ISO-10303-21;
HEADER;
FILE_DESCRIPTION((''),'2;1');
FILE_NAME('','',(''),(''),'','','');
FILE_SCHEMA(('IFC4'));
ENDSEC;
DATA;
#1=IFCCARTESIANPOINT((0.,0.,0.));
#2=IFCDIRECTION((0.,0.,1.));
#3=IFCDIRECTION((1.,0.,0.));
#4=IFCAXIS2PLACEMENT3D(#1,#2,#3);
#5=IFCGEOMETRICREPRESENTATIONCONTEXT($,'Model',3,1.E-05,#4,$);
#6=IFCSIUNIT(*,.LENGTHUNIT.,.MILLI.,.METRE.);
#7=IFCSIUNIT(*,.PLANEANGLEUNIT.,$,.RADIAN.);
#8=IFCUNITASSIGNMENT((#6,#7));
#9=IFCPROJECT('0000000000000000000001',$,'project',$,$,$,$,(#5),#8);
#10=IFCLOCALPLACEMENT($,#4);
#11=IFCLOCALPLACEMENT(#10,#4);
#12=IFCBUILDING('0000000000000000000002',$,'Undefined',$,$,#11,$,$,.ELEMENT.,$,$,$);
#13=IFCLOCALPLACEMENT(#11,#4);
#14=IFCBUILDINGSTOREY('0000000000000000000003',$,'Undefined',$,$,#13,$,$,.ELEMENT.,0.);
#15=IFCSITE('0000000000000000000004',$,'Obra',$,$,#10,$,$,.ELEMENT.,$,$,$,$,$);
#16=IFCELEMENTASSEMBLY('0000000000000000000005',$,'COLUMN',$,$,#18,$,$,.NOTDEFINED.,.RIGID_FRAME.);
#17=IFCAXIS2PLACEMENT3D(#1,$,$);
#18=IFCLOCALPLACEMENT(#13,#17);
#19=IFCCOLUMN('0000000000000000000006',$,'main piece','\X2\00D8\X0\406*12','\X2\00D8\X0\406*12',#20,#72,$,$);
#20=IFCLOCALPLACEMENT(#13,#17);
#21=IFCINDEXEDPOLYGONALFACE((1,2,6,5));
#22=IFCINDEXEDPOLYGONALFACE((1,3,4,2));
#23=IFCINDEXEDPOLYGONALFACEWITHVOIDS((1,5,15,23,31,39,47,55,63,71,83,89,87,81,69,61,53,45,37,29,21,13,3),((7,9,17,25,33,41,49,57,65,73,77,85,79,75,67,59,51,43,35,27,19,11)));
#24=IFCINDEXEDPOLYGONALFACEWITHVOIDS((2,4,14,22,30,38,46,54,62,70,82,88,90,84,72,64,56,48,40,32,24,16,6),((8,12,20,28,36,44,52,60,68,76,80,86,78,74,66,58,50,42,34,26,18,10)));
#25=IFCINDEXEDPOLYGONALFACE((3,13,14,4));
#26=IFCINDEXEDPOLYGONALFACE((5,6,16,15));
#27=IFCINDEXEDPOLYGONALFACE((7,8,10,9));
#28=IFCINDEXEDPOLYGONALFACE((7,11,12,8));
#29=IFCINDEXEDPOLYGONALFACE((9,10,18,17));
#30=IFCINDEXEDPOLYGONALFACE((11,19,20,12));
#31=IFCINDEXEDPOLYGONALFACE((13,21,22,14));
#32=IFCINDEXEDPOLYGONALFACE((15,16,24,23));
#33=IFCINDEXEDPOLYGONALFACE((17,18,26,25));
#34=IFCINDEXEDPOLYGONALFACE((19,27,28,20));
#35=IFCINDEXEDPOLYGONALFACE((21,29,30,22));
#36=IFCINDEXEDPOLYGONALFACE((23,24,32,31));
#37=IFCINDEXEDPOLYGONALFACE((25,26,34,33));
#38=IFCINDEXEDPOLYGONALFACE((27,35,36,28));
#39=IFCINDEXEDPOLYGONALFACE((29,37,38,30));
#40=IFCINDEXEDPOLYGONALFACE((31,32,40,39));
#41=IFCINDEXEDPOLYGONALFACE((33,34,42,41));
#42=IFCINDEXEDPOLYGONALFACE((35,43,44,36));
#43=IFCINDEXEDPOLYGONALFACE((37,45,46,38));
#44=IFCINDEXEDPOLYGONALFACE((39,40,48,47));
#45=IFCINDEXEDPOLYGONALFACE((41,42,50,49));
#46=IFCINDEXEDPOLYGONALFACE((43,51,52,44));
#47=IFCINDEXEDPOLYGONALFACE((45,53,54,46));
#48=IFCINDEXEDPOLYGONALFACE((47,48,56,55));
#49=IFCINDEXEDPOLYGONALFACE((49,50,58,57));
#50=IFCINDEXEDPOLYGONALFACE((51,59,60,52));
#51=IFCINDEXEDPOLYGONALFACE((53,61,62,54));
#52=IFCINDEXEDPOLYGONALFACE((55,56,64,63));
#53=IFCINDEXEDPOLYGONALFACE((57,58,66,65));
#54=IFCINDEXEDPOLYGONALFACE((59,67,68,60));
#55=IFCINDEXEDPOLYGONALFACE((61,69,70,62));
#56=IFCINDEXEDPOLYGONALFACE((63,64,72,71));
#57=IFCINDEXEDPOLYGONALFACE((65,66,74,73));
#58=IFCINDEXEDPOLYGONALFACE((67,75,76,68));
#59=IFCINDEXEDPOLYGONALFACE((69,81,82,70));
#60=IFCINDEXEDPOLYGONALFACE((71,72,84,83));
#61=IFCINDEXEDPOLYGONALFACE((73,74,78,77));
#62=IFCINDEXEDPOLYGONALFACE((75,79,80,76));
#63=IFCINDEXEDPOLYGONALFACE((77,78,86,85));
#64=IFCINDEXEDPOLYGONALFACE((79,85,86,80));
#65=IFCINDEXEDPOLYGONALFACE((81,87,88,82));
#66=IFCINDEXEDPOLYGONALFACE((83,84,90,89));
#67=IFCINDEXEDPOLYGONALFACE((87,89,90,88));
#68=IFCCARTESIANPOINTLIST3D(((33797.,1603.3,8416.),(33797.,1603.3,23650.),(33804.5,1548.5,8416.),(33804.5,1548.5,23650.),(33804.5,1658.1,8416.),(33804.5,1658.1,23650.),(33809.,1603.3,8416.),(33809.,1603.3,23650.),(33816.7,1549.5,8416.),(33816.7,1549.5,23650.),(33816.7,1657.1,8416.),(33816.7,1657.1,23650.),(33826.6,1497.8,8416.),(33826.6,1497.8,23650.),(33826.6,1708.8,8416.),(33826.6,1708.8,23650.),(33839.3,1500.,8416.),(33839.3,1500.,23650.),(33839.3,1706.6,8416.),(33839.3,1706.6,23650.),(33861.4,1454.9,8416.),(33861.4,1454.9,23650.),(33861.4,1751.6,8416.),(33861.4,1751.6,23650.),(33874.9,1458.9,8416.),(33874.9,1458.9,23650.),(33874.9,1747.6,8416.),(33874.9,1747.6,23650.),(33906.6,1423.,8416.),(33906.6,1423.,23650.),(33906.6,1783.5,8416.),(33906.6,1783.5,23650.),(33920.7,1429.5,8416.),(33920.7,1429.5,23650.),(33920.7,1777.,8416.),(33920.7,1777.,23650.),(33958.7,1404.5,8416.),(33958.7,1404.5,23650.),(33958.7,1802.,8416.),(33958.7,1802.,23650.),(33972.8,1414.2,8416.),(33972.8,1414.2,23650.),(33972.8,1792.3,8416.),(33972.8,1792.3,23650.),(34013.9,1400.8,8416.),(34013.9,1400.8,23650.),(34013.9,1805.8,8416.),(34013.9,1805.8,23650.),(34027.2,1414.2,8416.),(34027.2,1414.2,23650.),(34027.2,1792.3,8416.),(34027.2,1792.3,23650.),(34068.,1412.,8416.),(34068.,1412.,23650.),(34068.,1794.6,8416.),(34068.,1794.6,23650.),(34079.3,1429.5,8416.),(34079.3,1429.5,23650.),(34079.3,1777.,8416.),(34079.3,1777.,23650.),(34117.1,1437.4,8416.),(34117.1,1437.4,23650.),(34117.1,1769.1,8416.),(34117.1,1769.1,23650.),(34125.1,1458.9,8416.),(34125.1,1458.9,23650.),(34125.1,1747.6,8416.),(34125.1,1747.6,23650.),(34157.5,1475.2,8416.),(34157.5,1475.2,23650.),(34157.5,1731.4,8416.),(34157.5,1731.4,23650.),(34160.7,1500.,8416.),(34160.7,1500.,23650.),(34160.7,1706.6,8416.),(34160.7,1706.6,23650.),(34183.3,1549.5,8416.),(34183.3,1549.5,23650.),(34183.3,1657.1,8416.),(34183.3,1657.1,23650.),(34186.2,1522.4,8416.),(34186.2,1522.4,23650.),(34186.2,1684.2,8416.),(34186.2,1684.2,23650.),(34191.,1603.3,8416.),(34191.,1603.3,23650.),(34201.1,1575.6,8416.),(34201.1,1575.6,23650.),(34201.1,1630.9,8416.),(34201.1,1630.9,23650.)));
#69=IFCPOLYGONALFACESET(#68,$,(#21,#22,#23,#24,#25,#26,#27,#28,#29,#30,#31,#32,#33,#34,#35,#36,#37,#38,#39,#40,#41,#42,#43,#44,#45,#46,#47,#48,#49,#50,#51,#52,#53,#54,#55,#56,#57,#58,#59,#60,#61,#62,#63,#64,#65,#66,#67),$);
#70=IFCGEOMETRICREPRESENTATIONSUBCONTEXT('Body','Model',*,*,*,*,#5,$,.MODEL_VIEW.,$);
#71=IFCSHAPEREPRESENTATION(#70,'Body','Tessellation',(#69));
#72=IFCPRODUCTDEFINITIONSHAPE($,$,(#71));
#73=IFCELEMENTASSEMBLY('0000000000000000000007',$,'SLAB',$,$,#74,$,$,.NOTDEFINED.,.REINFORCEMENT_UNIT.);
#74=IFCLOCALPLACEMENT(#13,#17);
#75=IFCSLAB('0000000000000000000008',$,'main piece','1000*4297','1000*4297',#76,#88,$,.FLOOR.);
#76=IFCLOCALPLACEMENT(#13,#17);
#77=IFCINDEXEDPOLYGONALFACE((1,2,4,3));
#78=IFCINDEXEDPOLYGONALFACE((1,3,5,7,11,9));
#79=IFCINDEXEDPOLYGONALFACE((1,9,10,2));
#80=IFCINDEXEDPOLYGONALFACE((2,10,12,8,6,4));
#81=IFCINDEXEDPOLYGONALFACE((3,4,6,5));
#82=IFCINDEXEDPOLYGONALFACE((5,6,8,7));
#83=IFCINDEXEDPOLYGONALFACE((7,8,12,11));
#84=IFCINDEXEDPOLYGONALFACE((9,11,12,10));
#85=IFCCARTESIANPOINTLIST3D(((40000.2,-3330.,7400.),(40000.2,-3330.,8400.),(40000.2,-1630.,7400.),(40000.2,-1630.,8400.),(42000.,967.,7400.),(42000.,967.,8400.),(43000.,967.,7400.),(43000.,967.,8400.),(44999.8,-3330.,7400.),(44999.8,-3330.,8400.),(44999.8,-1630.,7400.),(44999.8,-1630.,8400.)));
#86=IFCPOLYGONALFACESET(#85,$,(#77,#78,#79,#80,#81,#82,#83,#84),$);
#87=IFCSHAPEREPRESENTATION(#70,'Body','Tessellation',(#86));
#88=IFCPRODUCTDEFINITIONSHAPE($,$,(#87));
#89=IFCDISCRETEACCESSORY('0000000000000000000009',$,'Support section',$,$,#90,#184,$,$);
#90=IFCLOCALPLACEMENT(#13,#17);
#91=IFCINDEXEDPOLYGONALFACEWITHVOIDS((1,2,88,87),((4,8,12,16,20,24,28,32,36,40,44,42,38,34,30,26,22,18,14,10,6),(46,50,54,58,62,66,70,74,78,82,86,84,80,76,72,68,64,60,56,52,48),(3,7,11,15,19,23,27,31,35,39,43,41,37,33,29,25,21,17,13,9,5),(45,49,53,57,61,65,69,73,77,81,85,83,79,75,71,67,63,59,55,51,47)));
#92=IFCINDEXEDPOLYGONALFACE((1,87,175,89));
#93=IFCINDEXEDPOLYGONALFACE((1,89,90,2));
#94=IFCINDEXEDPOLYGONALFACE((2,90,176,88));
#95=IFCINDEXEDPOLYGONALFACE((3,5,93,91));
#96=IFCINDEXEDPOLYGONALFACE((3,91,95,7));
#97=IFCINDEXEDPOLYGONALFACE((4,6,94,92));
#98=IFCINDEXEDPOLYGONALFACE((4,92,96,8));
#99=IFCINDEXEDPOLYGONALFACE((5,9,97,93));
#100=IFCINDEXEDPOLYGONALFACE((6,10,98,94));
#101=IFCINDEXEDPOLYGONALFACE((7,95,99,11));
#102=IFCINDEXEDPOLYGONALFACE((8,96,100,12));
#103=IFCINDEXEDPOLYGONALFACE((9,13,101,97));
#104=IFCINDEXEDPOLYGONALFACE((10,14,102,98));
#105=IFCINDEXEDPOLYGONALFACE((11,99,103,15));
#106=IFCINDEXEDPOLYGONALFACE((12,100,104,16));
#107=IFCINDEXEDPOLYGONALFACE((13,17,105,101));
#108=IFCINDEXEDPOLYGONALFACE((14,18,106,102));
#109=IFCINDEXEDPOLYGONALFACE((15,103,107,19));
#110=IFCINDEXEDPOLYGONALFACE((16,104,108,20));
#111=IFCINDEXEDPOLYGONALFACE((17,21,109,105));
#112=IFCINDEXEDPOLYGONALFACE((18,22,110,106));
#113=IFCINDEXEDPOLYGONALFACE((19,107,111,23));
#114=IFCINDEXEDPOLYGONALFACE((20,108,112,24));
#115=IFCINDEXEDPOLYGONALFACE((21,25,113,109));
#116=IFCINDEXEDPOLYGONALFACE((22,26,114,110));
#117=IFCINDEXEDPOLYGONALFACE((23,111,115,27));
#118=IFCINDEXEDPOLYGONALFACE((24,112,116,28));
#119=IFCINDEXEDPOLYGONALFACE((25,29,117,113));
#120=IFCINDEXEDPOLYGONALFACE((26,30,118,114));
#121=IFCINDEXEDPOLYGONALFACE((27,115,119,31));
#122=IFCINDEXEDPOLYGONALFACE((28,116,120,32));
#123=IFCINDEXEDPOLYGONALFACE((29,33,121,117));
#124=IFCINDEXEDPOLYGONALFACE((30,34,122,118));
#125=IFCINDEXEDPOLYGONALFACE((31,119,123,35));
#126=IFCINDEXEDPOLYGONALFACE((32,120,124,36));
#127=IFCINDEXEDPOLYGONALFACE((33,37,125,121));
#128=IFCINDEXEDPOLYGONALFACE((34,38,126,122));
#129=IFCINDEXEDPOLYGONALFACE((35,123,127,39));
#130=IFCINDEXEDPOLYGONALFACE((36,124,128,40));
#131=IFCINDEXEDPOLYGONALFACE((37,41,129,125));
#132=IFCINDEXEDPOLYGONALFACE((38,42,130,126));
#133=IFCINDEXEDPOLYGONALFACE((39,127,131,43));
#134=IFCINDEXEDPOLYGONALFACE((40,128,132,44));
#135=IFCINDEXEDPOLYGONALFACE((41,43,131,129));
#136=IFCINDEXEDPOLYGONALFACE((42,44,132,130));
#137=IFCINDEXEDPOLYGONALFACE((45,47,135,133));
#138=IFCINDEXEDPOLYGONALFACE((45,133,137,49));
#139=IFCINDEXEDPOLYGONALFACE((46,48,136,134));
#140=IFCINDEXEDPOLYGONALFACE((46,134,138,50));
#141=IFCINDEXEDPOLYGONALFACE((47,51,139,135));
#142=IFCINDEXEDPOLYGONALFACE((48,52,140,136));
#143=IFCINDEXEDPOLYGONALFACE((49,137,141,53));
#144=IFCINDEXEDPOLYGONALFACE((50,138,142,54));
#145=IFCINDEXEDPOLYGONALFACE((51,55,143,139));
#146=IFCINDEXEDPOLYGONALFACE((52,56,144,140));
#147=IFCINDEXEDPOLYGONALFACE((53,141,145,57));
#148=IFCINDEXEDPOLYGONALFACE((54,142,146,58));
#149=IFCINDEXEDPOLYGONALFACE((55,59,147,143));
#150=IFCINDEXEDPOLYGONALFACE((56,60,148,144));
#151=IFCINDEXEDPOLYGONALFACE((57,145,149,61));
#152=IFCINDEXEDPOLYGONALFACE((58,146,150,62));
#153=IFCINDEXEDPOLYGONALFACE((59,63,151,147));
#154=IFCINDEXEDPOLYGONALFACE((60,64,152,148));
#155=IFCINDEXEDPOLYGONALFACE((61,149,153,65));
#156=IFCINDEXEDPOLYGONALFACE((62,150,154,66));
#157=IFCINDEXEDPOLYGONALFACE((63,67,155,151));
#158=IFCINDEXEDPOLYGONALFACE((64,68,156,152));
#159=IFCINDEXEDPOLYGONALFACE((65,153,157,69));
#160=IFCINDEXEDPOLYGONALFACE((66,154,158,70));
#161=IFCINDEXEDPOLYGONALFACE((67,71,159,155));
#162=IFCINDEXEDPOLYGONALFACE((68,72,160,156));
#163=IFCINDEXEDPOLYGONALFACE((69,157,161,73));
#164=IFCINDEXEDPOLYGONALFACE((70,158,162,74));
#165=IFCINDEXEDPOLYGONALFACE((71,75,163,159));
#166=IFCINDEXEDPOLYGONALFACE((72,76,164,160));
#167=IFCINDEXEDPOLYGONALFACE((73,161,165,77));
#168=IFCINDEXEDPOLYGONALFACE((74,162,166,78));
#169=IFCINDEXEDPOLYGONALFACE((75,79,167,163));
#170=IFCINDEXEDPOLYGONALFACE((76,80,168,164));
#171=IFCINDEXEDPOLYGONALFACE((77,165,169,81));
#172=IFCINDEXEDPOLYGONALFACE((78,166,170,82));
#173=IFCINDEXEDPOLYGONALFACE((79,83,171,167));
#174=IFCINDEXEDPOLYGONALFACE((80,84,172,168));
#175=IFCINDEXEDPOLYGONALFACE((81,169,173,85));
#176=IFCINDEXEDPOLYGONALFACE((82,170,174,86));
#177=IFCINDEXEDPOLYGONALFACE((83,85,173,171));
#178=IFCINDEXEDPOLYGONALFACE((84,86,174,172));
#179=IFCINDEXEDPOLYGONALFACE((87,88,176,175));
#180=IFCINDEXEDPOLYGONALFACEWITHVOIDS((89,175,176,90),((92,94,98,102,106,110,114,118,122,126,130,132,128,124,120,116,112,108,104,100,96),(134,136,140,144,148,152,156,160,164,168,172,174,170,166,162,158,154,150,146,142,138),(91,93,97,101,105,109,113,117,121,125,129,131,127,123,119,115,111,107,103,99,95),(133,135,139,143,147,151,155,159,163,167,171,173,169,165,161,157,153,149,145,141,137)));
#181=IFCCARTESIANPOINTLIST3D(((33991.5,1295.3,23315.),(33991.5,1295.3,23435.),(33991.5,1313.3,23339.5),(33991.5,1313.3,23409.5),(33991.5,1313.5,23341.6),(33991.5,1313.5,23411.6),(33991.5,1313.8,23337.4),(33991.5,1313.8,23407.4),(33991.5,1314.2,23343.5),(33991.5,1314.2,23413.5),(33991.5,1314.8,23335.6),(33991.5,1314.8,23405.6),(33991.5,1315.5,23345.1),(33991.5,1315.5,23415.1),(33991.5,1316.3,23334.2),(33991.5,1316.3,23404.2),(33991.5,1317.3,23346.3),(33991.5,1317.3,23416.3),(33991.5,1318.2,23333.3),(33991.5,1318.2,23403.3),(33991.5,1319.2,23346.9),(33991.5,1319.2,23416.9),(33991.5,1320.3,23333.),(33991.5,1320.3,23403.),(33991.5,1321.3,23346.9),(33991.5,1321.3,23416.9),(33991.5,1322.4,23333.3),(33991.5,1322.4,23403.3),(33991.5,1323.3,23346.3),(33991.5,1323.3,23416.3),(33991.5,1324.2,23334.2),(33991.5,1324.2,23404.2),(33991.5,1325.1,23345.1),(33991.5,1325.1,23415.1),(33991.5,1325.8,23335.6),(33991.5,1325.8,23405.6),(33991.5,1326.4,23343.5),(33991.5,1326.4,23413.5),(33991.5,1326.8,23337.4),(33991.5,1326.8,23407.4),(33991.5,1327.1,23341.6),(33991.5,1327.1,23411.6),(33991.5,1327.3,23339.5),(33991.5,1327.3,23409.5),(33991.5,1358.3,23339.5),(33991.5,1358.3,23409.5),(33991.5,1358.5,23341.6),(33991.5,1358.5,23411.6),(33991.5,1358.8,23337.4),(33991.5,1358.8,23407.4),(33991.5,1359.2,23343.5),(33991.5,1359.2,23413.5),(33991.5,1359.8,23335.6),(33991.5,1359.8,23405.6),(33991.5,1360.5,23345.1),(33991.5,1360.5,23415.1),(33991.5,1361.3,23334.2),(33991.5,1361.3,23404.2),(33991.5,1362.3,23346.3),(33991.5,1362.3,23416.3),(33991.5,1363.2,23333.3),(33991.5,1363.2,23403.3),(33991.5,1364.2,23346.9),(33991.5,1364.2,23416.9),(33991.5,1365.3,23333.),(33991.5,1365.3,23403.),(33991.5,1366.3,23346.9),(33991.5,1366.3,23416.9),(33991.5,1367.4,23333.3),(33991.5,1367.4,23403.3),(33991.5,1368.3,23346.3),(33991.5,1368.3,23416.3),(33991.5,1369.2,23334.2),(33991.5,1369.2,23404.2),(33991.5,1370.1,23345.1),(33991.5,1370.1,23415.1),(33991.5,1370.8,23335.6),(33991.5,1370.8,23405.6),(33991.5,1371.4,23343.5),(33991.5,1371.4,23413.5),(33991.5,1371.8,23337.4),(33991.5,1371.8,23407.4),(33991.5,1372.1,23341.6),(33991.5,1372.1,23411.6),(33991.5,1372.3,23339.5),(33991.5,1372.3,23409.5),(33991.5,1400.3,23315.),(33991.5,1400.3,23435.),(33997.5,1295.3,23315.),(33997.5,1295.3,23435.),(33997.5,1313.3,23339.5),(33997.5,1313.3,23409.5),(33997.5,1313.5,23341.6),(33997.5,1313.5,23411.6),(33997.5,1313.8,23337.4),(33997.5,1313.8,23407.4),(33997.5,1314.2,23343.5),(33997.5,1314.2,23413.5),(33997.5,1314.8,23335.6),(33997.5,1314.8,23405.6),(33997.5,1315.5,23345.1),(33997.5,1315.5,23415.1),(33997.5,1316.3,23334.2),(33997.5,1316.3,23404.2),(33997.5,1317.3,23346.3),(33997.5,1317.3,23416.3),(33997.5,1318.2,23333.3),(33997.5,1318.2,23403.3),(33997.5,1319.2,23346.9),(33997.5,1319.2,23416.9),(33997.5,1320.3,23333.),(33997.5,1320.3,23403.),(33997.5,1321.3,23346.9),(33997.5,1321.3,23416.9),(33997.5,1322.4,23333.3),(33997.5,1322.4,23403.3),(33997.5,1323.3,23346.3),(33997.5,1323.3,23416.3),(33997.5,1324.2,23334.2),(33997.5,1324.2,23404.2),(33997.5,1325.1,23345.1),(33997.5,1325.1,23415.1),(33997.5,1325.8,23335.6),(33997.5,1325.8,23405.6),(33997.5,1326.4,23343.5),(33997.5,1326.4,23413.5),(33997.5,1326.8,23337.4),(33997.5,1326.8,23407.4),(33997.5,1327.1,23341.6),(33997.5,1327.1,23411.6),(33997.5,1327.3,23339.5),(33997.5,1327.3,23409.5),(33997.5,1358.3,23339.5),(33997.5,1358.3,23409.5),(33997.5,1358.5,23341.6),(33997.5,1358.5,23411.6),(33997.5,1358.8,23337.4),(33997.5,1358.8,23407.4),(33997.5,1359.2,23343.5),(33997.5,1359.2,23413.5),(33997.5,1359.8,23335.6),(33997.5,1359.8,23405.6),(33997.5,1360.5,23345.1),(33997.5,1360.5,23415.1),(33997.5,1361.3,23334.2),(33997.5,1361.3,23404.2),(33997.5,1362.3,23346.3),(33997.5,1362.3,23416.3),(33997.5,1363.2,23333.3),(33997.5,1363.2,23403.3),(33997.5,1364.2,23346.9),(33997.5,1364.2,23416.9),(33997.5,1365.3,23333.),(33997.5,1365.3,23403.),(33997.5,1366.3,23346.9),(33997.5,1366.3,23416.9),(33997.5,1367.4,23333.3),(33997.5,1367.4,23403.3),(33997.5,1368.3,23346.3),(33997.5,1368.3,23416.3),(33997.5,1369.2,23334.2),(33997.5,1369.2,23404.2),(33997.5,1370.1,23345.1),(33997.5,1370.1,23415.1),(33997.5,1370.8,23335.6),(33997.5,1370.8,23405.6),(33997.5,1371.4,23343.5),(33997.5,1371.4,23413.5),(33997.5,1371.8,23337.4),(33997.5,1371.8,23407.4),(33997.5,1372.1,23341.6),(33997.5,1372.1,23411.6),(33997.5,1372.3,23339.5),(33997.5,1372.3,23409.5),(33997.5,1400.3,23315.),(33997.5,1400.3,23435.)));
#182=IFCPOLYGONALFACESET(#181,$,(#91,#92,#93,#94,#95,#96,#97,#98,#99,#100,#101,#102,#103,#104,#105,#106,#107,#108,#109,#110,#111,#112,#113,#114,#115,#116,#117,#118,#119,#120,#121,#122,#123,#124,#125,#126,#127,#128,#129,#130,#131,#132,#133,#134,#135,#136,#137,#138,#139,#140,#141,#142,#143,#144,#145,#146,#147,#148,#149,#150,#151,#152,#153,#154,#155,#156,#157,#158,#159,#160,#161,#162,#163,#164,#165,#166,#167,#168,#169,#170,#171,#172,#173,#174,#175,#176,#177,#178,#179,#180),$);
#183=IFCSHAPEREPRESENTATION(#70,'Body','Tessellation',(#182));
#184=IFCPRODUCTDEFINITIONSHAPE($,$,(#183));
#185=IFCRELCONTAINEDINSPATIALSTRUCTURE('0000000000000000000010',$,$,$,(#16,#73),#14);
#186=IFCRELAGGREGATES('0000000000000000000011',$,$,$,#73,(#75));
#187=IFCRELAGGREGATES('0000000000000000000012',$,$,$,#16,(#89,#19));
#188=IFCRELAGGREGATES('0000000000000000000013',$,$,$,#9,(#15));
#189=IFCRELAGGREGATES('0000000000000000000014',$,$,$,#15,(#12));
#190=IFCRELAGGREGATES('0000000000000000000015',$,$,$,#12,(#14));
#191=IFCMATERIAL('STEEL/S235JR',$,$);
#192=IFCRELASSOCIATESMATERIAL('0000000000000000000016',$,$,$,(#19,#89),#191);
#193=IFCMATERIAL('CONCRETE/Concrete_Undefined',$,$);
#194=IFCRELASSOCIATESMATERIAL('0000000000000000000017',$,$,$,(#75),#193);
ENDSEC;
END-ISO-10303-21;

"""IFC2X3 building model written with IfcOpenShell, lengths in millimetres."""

from ifc_helpers import new_model, si_unit, frame, origin_with_axes, origin_2d_with_axis, place, context, subcontext, project, spatial, polyline, rectangle, circle, hollow_circle, outline, extrude, clip, halfspace, source, transform, mapped, material, element, aggregate, save


model = new_model("IFC2X3")

# Units and contexts
model_context = context("Model", 3, precision=1e-05, world=origin_with_axes())
body_context = subcontext(model_context, "Body", "Model", "MODEL_VIEW")
ifc_project = project(units=[si_unit("LENGTHUNIT", "METRE", prefix="MILLI"), si_unit("PLANEANGLEUNIT", "RADIAN")], contexts=[model_context])

# Site, building, storey
site_placement = place(None, origin_with_axes())
site = spatial("IfcSite", under=ifc_project, at=site_placement, Name="Obra", CompositionType="ELEMENT")
building_placement = place(site_placement, origin_with_axes())
building = spatial("IfcBuilding", under=site, at=building_placement, Name="Undefined", CompositionType="ELEMENT")
storey_placement = place(building_placement, origin_with_axes())
storey = spatial("IfcBuildingStorey", under=building, at=storey_placement, Name="Undefined", CompositionType="ELEMENT", Elevation=0.0)

# Element assembly, column
assembly_1_placement = place(storey_placement, origin_with_axes())
assembly_1 = element("IfcElementAssembly", 1, at=assembly_1_placement, inside=storey, Name="COLUMN", AssemblyPlace="NOTDEFINED", PredefinedType="RIGID_FRAME")
ifc_material_1 = material(Name="STEEL/S235JR")
column_placement = place(assembly_1_placement, frame((34000.0, 1603.3, 8400.0), z_axis=(0.0, 0.0, 1.0), x_axis=(0.0, 1.0, 0.0)))
column = element("IfcColumn", 2, at=column_placement, material=ifc_material_1, Name="main piece", Description="Ø406*12", ObjectType="Ø406*12", context=body_context, shape_type="Clipping", body=[
    clip(extrude(hollow_circle(Radius=203.0, WallThickness=12.0, at=origin_2d_with_axis()), frame((0.0, 0.0, 15250.0), z_axis=(0.0, 0.0, -1.0), x_axis=(0.0, 1.0, 0.0)), (0.0, 0.0, 1.0), 15234.0), halfspace(frame((-203.0, 0.0, 16.0), z_axis=(0.0, 0.0, 1.0), x_axis=(0.0, 1.0, 0.0)), True)),
])

# Element assembly, slab
assembly_2_placement = place(storey_placement, origin_with_axes())
assembly_2 = element("IfcElementAssembly", 3, at=assembly_2_placement, inside=storey, Name="SLAB", AssemblyPlace="NOTDEFINED", PredefinedType="REINFORCEMENT_UNIT")
ifc_material_2 = material(Name="CONCRETE/Concrete_Undefined")
slab_placement = place(assembly_2_placement, frame((40000.2, -1630.0, 7900.0), z_axis=(0.0, 0.0, 1.0), x_axis=(0.0, -1.0, 0.0)))
slab = element("IfcSlab", 4, at=slab_placement, material=ifc_material_2, Name="main piece", Description="1000*4297", ObjectType="1000*4297", PredefinedType="FLOOR", context=body_context, shape_type="SweptSolid", body=[
    extrude(outline(polyline([(0.0, 0.0), (1700.0, 0.0), (1700.0, 4999.6), (0.0, 4999.6), (-2597.0, 2999.8), (-2597.0, 1999.8), (0.0, 0.0)])), frame((0.0, 0.0, -500.0), z_axis=(0.0, 0.0, 1.0), x_axis=(1.0, 0.0, 0.0)), (0.0, 0.0, 1.0), 1000.0),
])
aggregate(assembly_2, [slab])

# Discrete accessory, opening
discrete_accessory_1_placement = place(assembly_1_placement, frame((33994.5, 1347.8, 23315.0), z_axis=(0.0, 0.0, 1.0), x_axis=(0.0, 1.0, 0.0)))
discrete_accessory_1 = element("IfcDiscreteAccessory", 5, at=discrete_accessory_1_placement, material=ifc_material_1, Name="Support section", context=body_context, shape_type="SweptSolid", body=[
    extrude(rectangle(XDim=6.0, YDim=105.0, at=origin_2d_with_axis()), frame((0.0, 0.0, 120.0), z_axis=(0.0, 0.0, -1.0), x_axis=(0.0, 1.0, 0.0)), (0.0, 0.0, 1.0), 120.0),
])
shared_shape_1 = source(origin_with_axes(), body_context, "Body", "SweptSolid", [
    extrude(circle(Radius=7.0, at=origin_2d_with_axis()), frame((0.0, -8.6, 0.0), z_axis=(0.0, 1.0, 0.0), x_axis=(1.0, 0.0, 0.0)), (0.0, 0.0, 1.0), 6.2),
])
opening_1_placement = place(assembly_1_placement, frame((34000.0, 1390.3, 23455.0), z_axis=(0.0, -1.0, 0.0), x_axis=(0.0, 0.0, -1.0)))
element("IfcOpeningElement", 6, at=opening_1_placement, cuts=discrete_accessory_1, ObjectType="Opening", context=body_context, shape_type="MappedRepresentation", body=[
    mapped(shared_shape_1, transform((45.0, 0.0, 25.0))),
    mapped(shared_shape_1, transform((45.0, 0.0, 70.0))),
    mapped(shared_shape_1, transform((115.0, 0.0, 25.0))),
    mapped(shared_shape_1, transform((115.0, 0.0, 70.0))),
])

aggregate(assembly_1, [discrete_accessory_1, column])

save(model, "model.ifc")
